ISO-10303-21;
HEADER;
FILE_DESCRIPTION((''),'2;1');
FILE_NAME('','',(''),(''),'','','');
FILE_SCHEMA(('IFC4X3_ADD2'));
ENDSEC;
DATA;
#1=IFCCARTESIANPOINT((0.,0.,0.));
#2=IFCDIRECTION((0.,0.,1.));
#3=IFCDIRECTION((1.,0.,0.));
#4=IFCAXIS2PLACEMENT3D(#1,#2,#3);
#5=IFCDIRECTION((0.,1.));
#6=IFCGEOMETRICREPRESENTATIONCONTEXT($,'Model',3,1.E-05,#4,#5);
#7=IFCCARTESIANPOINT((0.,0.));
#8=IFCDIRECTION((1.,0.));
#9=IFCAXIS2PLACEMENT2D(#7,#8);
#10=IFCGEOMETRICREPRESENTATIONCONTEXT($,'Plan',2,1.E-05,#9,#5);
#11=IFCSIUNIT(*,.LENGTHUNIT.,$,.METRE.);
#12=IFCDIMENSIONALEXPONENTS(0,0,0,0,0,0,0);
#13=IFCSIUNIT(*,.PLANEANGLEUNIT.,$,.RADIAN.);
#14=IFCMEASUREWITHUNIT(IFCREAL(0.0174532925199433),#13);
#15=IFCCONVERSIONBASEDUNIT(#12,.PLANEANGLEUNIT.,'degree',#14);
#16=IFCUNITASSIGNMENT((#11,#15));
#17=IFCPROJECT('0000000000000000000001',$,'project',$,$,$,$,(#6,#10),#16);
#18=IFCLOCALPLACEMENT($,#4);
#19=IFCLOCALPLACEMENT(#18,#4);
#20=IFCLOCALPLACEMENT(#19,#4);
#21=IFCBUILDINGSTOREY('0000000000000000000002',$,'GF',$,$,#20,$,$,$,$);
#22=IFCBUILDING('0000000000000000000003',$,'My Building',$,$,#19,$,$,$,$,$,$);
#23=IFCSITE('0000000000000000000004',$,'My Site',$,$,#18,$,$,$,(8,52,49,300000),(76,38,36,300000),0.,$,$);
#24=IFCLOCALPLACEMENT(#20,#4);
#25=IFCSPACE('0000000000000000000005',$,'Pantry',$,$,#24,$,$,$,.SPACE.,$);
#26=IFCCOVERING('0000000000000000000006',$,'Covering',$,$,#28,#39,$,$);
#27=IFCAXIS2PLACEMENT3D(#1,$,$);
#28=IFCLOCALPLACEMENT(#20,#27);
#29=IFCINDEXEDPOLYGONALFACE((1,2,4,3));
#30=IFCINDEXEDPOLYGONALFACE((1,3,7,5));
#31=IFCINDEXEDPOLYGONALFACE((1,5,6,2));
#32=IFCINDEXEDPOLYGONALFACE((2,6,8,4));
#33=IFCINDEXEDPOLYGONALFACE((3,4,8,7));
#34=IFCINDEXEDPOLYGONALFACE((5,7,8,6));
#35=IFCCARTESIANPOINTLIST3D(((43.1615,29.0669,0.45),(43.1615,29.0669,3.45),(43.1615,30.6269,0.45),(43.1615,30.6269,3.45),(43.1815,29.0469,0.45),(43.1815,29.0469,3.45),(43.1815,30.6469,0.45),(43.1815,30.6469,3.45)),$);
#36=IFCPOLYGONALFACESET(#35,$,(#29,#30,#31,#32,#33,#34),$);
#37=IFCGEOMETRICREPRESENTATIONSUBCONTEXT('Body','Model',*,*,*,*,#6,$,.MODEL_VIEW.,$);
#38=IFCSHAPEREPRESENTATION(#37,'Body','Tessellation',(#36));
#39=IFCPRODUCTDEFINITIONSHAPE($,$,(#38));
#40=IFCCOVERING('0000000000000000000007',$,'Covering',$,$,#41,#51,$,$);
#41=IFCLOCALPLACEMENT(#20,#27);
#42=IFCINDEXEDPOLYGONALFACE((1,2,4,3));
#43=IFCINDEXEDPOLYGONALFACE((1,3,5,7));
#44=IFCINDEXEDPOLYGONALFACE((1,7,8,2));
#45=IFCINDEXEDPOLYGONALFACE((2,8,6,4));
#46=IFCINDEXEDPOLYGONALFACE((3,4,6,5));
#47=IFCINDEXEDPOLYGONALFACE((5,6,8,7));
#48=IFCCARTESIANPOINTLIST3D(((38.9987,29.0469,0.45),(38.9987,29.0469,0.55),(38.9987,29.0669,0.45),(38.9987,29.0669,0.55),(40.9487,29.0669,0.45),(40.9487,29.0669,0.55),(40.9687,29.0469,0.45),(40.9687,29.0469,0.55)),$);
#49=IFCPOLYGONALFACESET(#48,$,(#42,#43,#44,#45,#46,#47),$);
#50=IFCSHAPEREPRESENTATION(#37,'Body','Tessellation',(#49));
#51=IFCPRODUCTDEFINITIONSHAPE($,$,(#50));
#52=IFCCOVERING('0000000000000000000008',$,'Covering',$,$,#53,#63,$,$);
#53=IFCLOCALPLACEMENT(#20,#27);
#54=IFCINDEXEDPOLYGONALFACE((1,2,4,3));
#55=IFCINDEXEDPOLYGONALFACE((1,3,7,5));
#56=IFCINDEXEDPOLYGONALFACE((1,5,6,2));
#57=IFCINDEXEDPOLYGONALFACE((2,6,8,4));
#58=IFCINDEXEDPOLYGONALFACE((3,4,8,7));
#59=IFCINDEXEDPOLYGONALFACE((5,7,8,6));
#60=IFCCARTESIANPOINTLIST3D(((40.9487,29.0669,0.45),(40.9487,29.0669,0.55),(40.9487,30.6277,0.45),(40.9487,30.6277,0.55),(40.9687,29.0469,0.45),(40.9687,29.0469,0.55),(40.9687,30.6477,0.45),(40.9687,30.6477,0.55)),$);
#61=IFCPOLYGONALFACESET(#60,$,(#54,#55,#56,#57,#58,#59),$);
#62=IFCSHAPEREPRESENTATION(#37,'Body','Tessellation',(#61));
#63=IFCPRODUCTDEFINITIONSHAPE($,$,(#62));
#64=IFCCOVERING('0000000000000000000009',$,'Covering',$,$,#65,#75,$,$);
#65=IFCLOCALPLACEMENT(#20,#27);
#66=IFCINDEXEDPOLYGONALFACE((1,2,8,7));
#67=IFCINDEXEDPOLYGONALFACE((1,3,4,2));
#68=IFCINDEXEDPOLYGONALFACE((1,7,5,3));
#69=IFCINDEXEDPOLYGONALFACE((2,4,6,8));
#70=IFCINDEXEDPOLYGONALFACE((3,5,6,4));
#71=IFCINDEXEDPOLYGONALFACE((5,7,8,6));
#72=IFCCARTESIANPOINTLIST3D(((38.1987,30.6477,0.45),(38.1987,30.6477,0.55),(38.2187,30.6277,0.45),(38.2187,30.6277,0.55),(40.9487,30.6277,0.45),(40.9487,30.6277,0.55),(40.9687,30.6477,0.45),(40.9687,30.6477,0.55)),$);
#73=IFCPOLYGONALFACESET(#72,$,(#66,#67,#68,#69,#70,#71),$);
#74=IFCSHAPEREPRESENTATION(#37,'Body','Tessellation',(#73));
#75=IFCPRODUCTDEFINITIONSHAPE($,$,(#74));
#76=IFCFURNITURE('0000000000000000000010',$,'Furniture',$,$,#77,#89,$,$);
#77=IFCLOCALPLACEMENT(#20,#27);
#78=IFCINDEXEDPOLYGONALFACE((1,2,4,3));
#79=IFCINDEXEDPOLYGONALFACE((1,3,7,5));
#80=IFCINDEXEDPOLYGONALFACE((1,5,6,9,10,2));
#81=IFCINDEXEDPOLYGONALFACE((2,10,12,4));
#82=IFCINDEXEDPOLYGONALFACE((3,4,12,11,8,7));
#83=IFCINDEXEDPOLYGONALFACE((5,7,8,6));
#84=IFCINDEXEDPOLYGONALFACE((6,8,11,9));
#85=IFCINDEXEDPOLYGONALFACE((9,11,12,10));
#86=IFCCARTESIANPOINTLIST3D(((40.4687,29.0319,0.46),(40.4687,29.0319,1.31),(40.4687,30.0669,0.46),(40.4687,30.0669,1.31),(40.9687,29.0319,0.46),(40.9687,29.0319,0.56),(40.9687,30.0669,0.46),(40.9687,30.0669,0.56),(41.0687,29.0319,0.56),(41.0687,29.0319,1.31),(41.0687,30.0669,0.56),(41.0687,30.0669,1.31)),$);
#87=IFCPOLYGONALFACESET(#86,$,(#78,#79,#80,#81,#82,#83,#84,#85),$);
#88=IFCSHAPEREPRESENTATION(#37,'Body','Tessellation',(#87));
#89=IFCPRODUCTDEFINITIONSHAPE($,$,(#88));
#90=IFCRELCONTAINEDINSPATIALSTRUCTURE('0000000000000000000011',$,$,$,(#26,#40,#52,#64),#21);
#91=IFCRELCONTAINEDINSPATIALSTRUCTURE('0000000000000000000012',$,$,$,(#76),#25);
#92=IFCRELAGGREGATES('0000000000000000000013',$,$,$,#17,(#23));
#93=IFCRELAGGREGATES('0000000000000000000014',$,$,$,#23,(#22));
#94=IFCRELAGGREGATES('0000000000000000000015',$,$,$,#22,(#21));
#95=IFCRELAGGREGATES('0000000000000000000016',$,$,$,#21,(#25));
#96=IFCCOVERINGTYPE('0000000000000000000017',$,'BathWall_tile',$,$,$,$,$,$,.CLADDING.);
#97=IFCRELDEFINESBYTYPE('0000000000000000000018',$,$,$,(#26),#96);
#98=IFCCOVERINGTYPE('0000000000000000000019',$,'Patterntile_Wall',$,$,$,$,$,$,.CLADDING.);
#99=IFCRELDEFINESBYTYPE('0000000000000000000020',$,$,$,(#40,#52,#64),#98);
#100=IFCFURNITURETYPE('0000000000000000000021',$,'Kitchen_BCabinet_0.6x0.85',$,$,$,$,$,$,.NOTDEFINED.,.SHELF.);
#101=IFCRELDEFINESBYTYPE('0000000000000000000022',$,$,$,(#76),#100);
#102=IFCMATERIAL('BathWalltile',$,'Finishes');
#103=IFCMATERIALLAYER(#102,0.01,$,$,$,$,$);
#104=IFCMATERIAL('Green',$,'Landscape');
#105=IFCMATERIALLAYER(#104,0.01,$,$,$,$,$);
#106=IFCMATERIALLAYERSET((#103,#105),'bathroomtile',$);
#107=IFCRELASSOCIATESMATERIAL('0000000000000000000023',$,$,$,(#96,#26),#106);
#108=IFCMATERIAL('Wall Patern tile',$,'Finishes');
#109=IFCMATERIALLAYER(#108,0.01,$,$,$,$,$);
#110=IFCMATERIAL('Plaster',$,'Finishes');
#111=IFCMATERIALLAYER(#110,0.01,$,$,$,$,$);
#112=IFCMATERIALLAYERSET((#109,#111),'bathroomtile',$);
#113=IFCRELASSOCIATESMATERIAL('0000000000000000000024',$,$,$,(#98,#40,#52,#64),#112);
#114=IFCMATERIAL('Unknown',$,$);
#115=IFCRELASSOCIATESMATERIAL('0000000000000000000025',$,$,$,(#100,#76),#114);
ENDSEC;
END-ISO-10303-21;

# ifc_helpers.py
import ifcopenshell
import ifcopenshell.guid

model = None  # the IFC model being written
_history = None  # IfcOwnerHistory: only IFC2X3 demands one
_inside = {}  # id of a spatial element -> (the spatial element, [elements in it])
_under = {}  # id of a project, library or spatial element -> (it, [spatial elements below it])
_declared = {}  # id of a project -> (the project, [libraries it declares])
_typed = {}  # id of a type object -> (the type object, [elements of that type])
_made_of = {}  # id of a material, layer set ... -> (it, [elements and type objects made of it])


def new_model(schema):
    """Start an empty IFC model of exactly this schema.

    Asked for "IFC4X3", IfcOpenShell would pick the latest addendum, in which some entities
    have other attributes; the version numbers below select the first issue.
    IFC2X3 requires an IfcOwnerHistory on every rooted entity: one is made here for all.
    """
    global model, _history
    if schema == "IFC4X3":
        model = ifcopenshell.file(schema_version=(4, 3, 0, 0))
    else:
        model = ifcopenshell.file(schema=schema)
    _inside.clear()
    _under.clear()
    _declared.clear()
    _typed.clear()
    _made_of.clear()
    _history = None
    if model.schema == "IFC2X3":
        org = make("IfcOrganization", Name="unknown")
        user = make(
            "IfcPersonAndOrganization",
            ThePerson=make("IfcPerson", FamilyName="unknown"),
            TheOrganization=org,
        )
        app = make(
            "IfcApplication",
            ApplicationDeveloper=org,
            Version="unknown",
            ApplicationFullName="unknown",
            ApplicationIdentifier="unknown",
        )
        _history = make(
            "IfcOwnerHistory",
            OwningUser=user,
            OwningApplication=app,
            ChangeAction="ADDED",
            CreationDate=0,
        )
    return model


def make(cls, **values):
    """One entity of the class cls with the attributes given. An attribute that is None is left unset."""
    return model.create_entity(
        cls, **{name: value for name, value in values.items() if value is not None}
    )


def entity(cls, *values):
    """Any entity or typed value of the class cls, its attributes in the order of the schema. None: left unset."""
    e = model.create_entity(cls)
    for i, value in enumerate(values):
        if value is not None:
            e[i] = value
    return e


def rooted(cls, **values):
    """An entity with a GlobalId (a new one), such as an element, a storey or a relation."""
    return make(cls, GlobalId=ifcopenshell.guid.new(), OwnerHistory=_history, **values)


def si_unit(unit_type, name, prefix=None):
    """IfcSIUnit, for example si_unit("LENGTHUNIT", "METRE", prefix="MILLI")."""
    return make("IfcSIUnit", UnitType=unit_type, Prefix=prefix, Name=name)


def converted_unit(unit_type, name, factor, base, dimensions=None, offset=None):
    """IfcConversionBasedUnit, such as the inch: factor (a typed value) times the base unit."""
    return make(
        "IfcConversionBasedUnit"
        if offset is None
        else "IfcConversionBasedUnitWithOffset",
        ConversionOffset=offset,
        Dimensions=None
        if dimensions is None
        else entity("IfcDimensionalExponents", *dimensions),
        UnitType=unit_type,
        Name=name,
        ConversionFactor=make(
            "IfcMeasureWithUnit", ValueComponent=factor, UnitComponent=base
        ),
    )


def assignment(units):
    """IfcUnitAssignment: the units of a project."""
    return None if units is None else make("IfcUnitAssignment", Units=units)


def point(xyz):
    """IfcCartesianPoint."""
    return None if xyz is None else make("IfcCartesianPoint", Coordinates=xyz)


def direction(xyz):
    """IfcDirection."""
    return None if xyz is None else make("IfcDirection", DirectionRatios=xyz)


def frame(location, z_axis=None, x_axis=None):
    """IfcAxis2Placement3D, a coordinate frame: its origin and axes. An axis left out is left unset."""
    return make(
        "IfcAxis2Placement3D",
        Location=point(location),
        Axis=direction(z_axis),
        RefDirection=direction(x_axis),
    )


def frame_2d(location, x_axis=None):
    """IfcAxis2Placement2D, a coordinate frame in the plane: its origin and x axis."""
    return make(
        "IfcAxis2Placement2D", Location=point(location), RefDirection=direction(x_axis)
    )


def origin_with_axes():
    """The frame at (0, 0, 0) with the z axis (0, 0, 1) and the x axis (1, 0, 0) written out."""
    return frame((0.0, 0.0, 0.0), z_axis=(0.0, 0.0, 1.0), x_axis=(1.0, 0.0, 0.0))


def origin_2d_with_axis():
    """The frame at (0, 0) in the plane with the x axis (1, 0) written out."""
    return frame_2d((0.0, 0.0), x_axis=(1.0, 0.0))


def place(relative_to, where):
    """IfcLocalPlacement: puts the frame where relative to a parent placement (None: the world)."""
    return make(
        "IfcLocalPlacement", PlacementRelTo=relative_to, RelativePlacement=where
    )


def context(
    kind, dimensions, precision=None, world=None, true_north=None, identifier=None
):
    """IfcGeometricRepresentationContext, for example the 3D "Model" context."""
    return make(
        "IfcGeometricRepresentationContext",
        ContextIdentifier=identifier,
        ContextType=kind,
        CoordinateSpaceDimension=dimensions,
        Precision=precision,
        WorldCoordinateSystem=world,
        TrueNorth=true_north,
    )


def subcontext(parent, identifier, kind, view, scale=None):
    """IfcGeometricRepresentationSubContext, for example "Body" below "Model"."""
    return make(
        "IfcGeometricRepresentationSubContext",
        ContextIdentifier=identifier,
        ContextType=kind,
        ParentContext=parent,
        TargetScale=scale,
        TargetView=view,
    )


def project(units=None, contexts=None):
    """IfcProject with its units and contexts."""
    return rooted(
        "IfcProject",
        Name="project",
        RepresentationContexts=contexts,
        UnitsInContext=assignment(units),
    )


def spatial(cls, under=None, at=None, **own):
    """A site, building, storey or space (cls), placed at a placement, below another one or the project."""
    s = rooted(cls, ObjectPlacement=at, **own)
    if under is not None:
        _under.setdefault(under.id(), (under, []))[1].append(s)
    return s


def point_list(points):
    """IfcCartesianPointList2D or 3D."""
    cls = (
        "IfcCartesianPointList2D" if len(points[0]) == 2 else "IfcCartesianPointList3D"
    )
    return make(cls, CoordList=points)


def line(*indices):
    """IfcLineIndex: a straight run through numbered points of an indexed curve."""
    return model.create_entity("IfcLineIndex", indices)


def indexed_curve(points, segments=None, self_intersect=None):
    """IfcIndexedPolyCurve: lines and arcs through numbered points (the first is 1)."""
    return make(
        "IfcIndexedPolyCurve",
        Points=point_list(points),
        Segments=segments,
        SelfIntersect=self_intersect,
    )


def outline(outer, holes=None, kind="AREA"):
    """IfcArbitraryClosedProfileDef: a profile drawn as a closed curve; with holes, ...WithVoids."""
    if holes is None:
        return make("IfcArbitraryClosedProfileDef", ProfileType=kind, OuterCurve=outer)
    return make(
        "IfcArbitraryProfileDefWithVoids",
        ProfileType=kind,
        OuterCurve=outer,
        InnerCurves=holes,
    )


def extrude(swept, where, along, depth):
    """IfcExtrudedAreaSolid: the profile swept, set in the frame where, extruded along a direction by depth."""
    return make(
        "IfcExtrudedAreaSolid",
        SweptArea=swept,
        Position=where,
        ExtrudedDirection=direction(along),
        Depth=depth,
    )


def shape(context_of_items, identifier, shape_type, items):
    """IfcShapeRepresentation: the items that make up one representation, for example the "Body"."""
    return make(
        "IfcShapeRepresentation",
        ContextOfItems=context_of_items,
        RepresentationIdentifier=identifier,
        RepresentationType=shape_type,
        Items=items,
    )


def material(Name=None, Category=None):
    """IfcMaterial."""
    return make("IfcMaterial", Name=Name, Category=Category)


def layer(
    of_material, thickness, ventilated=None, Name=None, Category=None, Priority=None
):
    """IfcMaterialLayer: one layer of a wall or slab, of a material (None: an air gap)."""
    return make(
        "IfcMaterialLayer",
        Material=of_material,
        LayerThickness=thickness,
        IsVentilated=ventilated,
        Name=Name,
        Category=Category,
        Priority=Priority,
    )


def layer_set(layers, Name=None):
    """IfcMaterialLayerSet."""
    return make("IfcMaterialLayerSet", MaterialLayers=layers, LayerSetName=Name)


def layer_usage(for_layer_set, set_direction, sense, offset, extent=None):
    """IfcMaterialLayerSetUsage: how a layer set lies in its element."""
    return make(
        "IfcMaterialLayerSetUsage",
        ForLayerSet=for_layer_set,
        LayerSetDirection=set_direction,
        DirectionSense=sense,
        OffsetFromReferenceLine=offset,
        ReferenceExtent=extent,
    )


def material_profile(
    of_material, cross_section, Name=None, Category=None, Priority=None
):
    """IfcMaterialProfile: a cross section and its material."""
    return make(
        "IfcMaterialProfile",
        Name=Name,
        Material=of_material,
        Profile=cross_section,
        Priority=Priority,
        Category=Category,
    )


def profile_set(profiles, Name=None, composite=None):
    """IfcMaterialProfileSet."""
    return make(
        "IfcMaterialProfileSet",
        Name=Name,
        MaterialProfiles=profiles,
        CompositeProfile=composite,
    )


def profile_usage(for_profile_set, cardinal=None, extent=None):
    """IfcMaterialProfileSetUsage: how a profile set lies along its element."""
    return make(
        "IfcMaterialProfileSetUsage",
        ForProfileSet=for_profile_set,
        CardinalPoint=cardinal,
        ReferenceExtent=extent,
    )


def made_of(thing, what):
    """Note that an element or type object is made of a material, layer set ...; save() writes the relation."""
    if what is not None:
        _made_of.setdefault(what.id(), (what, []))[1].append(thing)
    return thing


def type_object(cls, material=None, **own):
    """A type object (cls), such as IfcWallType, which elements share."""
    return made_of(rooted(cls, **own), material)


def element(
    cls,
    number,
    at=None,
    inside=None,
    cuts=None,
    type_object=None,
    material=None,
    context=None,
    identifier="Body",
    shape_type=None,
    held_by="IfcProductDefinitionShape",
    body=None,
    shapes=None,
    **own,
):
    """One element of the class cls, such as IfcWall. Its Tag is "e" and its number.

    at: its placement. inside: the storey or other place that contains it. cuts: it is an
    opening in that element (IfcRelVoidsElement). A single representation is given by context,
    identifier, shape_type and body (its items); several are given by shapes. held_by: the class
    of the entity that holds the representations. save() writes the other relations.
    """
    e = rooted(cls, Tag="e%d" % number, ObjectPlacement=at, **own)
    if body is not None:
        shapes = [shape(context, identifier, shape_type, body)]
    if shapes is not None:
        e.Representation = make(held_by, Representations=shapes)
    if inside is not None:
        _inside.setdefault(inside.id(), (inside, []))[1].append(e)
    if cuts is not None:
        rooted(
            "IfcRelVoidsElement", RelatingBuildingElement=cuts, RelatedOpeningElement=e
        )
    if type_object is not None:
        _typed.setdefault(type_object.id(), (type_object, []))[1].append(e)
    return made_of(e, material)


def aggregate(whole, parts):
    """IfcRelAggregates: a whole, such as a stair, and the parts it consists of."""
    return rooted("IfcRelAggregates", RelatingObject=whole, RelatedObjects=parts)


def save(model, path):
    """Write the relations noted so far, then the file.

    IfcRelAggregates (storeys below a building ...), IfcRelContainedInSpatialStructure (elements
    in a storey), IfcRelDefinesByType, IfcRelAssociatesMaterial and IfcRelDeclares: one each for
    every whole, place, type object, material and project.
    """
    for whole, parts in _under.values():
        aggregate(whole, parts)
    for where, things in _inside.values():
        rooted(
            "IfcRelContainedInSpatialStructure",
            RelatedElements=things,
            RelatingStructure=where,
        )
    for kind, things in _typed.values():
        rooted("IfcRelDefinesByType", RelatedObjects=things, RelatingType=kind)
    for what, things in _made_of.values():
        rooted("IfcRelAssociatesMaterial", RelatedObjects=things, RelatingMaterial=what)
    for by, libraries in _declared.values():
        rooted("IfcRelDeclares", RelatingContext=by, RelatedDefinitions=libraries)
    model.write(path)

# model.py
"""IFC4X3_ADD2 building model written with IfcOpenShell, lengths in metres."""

from ifc_helpers import new_model, entity, si_unit, converted_unit, direction, frame, origin_with_axes, origin_2d_with_axis, place, context, subcontext, project, spatial, line, indexed_curve, outline, extrude, material, layer, layer_set, layer_usage, material_profile, profile_set, profile_usage, type_object, element, save


model = new_model("IFC4X3_ADD2")

# Units and contexts
model_context = context("Model", 3, precision=1e-05, world=origin_with_axes(), true_north=direction((0.0, 1.0)))
plan_context = context("Plan", 2, precision=1e-05, world=origin_2d_with_axis(), true_north=direction((0.0, 1.0)))
body_context = subcontext(model_context, "Body", "Model", "MODEL_VIEW")
ifc_project = project(units=[si_unit("LENGTHUNIT", "METRE"), converted_unit("PLANEANGLEUNIT", "degree", entity("IfcReal", 0.0174532925199433), si_unit("PLANEANGLEUNIT", "RADIAN"), dimensions=[0, 0, 0, 0, 0, 0, 0])], contexts=[model_context, plan_context])

# Site, building, storey
site_placement = place(None, origin_with_axes())
site = spatial("IfcSite", under=ifc_project, at=site_placement, Name="My Site", RefLatitude=(8, 52, 49, 300000), RefLongitude=(76, 38, 36, 300000), RefElevation=0.0)
building_placement = place(site_placement, origin_with_axes())
building = spatial("IfcBuilding", under=site, at=building_placement, Name="My Building")
storey_placement = place(building_placement, origin_with_axes())
storey = spatial("IfcBuildingStorey", under=building, at=storey_placement, Name="GF")

# Shared definitions
ifc_material_1 = material(Name="Unknown")

# Coverings
ifc_material_2 = material(Name="BathWalltile", Category="Finishes")
ifc_layer_1 = layer(ifc_material_2, 0.01)
ifc_material_3 = material(Name="Green", Category="Landscape")
ifc_layer_2 = layer(ifc_material_3, 0.01)
ifc_layer_set_1 = layer_set([ifc_layer_1, ifc_layer_2], Name="bathroomtile")
covering_type_1 = type_object("IfcCoveringType", Name="BathWall_tile", PredefinedType="CLADDING", material=ifc_layer_set_1)
ifc_layer_usage_1 = layer_usage(ifc_layer_set_1, "AXIS2", "NEGATIVE", 0.0)
covering_1_placement = place(storey_placement, frame((43.1615, 29.0669, 0.45), z_axis=(0.0, 0.0, 1.0), x_axis=(0.0, 1.0, 0.0)))
element("IfcCovering", 1, at=covering_1_placement, inside=storey, type_object=covering_type_1, material=ifc_layer_usage_1, Name="Covering", context=body_context, shape_type="SweptSolid", body=[
    extrude(outline(indexed_curve([(-0.02, -0.02), (0.0, 0.0), (1.56, 0.0), (1.58, -0.02)], segments=[line(1, 2, 3, 4, 1)])), origin_with_axes(), (0.0, 0.0, 1.0), 3.0),
])
ifc_material_4 = material(Name="Wall Patern tile", Category="Finishes")
ifc_layer_3 = layer(ifc_material_4, 0.01)
ifc_material_5 = material(Name="Plaster", Category="Finishes")
ifc_layer_4 = layer(ifc_material_5, 0.01)
ifc_layer_set_2 = layer_set([ifc_layer_3, ifc_layer_4], Name="bathroomtile")
ifc_layer_usage_2 = layer_usage(ifc_layer_set_2, "AXIS2", "POSITIVE", 0.0)
covering_type_2 = type_object("IfcCoveringType", Name="Patterntile_Wall", PredefinedType="CLADDING", material=ifc_layer_set_2)
covering_2_placement = place(storey_placement, frame((40.9487, 29.0669, 0.45), z_axis=(0.0, 0.0, 1.0), x_axis=(-1.0, 0.000001, 0.0)))
element("IfcCovering", 2, at=covering_2_placement, inside=storey, type_object=covering_type_2, material=ifc_layer_usage_2, Name="Covering", context=body_context, shape_type="SweptSolid", body=[
    extrude(outline(indexed_curve([(0.0, 0.0), (-0.02, 0.02), (1.95, 0.02), (1.95, 0.0)], segments=[line(1, 2, 3, 4, 1)])), origin_with_axes(), (0.0, 0.0, 1.0), 0.1),
])
ifc_layer_usage_3 = layer_usage(ifc_layer_set_2, "AXIS2", "NEGATIVE", 0.0)
covering_3_placement = place(storey_placement, frame((40.9487, 29.0669, 0.45), z_axis=(0.0, 0.0, 1.0), x_axis=(0.0, 1.0, 0.0)))
element("IfcCovering", 3, at=covering_3_placement, inside=storey, type_object=covering_type_2, material=ifc_layer_usage_3, Name="Covering", context=body_context, shape_type="SweptSolid", body=[
    extrude(outline(indexed_curve([(-0.02, -0.02), (0.0, 0.0), (1.5608, 0.0), (1.5808, -0.02)], segments=[line(1, 2, 3, 4, 1)])), origin_with_axes(), (0.0, 0.0, 1.0), 0.1),
])
ifc_layer_usage_4 = layer_usage(ifc_layer_set_2, "AXIS2", "NEGATIVE", 0.0)
covering_4_placement = place(storey_placement, frame((40.9487, 30.6277, 0.45), z_axis=(0.0, 0.0, 1.0), x_axis=(-1.0, 0.000001, 0.0)))
element("IfcCovering", 4, at=covering_4_placement, inside=storey, type_object=covering_type_2, material=ifc_layer_usage_4, Name="Covering", context=body_context, shape_type="SweptSolid", body=[
    extrude(outline(indexed_curve([(-0.02, -0.02), (0.0, 0.0), (2.73, 0.0), (2.75, -0.02)], segments=[line(1, 2, 3, 4, 1)])), origin_with_axes(), (0.0, 0.0, 1.0), 0.1),
])

# Shared definitions
space_placement = place(storey_placement, origin_with_axes())
space = spatial("IfcSpace", under=storey, at=space_placement, Name="Pantry", PredefinedType="SPACE")

# Furniture
ifc_material_profile_1 = material_profile(ifc_material_1, outline(indexed_curve([(0.5, 0.0), (0.0, 0.0), (0.0, 0.85), (0.6, 0.85), (0.6, 0.1), (0.5, 0.1), (0.5, 0.0)])))
ifc_profile_set_1 = profile_set([ifc_material_profile_1], Name="blank")
ifc_profile_usage_1 = profile_usage(ifc_profile_set_1, cardinal=5)
furniture_type = type_object("IfcFurnitureType", Name="Kitchen_BCabinet_0.6x0.85", AssemblyPlace="NOTDEFINED", PredefinedType="SHELF", material=ifc_profile_set_1)
furniture_placement = place(space_placement, frame((40.4687, 30.0669, 0.46), z_axis=(0.0, -1.0, 0.0), x_axis=(1.0, 0.0, 0.0)))
element("IfcFurniture", 5, at=furniture_placement, inside=space, type_object=furniture_type, material=ifc_profile_usage_1, Name="Furniture", context=body_context, shape_type="SweptSolid", body=[
    extrude(outline(indexed_curve([(0.5, 0.0), (0.0, 0.0), (0.0, 0.85), (0.6, 0.85), (0.6, 0.1), (0.5, 0.1), (0.5, 0.0)])), origin_with_axes(), (0.0, 0.0, 1.0), 1.035),
])

save(model, "model.ifc")
